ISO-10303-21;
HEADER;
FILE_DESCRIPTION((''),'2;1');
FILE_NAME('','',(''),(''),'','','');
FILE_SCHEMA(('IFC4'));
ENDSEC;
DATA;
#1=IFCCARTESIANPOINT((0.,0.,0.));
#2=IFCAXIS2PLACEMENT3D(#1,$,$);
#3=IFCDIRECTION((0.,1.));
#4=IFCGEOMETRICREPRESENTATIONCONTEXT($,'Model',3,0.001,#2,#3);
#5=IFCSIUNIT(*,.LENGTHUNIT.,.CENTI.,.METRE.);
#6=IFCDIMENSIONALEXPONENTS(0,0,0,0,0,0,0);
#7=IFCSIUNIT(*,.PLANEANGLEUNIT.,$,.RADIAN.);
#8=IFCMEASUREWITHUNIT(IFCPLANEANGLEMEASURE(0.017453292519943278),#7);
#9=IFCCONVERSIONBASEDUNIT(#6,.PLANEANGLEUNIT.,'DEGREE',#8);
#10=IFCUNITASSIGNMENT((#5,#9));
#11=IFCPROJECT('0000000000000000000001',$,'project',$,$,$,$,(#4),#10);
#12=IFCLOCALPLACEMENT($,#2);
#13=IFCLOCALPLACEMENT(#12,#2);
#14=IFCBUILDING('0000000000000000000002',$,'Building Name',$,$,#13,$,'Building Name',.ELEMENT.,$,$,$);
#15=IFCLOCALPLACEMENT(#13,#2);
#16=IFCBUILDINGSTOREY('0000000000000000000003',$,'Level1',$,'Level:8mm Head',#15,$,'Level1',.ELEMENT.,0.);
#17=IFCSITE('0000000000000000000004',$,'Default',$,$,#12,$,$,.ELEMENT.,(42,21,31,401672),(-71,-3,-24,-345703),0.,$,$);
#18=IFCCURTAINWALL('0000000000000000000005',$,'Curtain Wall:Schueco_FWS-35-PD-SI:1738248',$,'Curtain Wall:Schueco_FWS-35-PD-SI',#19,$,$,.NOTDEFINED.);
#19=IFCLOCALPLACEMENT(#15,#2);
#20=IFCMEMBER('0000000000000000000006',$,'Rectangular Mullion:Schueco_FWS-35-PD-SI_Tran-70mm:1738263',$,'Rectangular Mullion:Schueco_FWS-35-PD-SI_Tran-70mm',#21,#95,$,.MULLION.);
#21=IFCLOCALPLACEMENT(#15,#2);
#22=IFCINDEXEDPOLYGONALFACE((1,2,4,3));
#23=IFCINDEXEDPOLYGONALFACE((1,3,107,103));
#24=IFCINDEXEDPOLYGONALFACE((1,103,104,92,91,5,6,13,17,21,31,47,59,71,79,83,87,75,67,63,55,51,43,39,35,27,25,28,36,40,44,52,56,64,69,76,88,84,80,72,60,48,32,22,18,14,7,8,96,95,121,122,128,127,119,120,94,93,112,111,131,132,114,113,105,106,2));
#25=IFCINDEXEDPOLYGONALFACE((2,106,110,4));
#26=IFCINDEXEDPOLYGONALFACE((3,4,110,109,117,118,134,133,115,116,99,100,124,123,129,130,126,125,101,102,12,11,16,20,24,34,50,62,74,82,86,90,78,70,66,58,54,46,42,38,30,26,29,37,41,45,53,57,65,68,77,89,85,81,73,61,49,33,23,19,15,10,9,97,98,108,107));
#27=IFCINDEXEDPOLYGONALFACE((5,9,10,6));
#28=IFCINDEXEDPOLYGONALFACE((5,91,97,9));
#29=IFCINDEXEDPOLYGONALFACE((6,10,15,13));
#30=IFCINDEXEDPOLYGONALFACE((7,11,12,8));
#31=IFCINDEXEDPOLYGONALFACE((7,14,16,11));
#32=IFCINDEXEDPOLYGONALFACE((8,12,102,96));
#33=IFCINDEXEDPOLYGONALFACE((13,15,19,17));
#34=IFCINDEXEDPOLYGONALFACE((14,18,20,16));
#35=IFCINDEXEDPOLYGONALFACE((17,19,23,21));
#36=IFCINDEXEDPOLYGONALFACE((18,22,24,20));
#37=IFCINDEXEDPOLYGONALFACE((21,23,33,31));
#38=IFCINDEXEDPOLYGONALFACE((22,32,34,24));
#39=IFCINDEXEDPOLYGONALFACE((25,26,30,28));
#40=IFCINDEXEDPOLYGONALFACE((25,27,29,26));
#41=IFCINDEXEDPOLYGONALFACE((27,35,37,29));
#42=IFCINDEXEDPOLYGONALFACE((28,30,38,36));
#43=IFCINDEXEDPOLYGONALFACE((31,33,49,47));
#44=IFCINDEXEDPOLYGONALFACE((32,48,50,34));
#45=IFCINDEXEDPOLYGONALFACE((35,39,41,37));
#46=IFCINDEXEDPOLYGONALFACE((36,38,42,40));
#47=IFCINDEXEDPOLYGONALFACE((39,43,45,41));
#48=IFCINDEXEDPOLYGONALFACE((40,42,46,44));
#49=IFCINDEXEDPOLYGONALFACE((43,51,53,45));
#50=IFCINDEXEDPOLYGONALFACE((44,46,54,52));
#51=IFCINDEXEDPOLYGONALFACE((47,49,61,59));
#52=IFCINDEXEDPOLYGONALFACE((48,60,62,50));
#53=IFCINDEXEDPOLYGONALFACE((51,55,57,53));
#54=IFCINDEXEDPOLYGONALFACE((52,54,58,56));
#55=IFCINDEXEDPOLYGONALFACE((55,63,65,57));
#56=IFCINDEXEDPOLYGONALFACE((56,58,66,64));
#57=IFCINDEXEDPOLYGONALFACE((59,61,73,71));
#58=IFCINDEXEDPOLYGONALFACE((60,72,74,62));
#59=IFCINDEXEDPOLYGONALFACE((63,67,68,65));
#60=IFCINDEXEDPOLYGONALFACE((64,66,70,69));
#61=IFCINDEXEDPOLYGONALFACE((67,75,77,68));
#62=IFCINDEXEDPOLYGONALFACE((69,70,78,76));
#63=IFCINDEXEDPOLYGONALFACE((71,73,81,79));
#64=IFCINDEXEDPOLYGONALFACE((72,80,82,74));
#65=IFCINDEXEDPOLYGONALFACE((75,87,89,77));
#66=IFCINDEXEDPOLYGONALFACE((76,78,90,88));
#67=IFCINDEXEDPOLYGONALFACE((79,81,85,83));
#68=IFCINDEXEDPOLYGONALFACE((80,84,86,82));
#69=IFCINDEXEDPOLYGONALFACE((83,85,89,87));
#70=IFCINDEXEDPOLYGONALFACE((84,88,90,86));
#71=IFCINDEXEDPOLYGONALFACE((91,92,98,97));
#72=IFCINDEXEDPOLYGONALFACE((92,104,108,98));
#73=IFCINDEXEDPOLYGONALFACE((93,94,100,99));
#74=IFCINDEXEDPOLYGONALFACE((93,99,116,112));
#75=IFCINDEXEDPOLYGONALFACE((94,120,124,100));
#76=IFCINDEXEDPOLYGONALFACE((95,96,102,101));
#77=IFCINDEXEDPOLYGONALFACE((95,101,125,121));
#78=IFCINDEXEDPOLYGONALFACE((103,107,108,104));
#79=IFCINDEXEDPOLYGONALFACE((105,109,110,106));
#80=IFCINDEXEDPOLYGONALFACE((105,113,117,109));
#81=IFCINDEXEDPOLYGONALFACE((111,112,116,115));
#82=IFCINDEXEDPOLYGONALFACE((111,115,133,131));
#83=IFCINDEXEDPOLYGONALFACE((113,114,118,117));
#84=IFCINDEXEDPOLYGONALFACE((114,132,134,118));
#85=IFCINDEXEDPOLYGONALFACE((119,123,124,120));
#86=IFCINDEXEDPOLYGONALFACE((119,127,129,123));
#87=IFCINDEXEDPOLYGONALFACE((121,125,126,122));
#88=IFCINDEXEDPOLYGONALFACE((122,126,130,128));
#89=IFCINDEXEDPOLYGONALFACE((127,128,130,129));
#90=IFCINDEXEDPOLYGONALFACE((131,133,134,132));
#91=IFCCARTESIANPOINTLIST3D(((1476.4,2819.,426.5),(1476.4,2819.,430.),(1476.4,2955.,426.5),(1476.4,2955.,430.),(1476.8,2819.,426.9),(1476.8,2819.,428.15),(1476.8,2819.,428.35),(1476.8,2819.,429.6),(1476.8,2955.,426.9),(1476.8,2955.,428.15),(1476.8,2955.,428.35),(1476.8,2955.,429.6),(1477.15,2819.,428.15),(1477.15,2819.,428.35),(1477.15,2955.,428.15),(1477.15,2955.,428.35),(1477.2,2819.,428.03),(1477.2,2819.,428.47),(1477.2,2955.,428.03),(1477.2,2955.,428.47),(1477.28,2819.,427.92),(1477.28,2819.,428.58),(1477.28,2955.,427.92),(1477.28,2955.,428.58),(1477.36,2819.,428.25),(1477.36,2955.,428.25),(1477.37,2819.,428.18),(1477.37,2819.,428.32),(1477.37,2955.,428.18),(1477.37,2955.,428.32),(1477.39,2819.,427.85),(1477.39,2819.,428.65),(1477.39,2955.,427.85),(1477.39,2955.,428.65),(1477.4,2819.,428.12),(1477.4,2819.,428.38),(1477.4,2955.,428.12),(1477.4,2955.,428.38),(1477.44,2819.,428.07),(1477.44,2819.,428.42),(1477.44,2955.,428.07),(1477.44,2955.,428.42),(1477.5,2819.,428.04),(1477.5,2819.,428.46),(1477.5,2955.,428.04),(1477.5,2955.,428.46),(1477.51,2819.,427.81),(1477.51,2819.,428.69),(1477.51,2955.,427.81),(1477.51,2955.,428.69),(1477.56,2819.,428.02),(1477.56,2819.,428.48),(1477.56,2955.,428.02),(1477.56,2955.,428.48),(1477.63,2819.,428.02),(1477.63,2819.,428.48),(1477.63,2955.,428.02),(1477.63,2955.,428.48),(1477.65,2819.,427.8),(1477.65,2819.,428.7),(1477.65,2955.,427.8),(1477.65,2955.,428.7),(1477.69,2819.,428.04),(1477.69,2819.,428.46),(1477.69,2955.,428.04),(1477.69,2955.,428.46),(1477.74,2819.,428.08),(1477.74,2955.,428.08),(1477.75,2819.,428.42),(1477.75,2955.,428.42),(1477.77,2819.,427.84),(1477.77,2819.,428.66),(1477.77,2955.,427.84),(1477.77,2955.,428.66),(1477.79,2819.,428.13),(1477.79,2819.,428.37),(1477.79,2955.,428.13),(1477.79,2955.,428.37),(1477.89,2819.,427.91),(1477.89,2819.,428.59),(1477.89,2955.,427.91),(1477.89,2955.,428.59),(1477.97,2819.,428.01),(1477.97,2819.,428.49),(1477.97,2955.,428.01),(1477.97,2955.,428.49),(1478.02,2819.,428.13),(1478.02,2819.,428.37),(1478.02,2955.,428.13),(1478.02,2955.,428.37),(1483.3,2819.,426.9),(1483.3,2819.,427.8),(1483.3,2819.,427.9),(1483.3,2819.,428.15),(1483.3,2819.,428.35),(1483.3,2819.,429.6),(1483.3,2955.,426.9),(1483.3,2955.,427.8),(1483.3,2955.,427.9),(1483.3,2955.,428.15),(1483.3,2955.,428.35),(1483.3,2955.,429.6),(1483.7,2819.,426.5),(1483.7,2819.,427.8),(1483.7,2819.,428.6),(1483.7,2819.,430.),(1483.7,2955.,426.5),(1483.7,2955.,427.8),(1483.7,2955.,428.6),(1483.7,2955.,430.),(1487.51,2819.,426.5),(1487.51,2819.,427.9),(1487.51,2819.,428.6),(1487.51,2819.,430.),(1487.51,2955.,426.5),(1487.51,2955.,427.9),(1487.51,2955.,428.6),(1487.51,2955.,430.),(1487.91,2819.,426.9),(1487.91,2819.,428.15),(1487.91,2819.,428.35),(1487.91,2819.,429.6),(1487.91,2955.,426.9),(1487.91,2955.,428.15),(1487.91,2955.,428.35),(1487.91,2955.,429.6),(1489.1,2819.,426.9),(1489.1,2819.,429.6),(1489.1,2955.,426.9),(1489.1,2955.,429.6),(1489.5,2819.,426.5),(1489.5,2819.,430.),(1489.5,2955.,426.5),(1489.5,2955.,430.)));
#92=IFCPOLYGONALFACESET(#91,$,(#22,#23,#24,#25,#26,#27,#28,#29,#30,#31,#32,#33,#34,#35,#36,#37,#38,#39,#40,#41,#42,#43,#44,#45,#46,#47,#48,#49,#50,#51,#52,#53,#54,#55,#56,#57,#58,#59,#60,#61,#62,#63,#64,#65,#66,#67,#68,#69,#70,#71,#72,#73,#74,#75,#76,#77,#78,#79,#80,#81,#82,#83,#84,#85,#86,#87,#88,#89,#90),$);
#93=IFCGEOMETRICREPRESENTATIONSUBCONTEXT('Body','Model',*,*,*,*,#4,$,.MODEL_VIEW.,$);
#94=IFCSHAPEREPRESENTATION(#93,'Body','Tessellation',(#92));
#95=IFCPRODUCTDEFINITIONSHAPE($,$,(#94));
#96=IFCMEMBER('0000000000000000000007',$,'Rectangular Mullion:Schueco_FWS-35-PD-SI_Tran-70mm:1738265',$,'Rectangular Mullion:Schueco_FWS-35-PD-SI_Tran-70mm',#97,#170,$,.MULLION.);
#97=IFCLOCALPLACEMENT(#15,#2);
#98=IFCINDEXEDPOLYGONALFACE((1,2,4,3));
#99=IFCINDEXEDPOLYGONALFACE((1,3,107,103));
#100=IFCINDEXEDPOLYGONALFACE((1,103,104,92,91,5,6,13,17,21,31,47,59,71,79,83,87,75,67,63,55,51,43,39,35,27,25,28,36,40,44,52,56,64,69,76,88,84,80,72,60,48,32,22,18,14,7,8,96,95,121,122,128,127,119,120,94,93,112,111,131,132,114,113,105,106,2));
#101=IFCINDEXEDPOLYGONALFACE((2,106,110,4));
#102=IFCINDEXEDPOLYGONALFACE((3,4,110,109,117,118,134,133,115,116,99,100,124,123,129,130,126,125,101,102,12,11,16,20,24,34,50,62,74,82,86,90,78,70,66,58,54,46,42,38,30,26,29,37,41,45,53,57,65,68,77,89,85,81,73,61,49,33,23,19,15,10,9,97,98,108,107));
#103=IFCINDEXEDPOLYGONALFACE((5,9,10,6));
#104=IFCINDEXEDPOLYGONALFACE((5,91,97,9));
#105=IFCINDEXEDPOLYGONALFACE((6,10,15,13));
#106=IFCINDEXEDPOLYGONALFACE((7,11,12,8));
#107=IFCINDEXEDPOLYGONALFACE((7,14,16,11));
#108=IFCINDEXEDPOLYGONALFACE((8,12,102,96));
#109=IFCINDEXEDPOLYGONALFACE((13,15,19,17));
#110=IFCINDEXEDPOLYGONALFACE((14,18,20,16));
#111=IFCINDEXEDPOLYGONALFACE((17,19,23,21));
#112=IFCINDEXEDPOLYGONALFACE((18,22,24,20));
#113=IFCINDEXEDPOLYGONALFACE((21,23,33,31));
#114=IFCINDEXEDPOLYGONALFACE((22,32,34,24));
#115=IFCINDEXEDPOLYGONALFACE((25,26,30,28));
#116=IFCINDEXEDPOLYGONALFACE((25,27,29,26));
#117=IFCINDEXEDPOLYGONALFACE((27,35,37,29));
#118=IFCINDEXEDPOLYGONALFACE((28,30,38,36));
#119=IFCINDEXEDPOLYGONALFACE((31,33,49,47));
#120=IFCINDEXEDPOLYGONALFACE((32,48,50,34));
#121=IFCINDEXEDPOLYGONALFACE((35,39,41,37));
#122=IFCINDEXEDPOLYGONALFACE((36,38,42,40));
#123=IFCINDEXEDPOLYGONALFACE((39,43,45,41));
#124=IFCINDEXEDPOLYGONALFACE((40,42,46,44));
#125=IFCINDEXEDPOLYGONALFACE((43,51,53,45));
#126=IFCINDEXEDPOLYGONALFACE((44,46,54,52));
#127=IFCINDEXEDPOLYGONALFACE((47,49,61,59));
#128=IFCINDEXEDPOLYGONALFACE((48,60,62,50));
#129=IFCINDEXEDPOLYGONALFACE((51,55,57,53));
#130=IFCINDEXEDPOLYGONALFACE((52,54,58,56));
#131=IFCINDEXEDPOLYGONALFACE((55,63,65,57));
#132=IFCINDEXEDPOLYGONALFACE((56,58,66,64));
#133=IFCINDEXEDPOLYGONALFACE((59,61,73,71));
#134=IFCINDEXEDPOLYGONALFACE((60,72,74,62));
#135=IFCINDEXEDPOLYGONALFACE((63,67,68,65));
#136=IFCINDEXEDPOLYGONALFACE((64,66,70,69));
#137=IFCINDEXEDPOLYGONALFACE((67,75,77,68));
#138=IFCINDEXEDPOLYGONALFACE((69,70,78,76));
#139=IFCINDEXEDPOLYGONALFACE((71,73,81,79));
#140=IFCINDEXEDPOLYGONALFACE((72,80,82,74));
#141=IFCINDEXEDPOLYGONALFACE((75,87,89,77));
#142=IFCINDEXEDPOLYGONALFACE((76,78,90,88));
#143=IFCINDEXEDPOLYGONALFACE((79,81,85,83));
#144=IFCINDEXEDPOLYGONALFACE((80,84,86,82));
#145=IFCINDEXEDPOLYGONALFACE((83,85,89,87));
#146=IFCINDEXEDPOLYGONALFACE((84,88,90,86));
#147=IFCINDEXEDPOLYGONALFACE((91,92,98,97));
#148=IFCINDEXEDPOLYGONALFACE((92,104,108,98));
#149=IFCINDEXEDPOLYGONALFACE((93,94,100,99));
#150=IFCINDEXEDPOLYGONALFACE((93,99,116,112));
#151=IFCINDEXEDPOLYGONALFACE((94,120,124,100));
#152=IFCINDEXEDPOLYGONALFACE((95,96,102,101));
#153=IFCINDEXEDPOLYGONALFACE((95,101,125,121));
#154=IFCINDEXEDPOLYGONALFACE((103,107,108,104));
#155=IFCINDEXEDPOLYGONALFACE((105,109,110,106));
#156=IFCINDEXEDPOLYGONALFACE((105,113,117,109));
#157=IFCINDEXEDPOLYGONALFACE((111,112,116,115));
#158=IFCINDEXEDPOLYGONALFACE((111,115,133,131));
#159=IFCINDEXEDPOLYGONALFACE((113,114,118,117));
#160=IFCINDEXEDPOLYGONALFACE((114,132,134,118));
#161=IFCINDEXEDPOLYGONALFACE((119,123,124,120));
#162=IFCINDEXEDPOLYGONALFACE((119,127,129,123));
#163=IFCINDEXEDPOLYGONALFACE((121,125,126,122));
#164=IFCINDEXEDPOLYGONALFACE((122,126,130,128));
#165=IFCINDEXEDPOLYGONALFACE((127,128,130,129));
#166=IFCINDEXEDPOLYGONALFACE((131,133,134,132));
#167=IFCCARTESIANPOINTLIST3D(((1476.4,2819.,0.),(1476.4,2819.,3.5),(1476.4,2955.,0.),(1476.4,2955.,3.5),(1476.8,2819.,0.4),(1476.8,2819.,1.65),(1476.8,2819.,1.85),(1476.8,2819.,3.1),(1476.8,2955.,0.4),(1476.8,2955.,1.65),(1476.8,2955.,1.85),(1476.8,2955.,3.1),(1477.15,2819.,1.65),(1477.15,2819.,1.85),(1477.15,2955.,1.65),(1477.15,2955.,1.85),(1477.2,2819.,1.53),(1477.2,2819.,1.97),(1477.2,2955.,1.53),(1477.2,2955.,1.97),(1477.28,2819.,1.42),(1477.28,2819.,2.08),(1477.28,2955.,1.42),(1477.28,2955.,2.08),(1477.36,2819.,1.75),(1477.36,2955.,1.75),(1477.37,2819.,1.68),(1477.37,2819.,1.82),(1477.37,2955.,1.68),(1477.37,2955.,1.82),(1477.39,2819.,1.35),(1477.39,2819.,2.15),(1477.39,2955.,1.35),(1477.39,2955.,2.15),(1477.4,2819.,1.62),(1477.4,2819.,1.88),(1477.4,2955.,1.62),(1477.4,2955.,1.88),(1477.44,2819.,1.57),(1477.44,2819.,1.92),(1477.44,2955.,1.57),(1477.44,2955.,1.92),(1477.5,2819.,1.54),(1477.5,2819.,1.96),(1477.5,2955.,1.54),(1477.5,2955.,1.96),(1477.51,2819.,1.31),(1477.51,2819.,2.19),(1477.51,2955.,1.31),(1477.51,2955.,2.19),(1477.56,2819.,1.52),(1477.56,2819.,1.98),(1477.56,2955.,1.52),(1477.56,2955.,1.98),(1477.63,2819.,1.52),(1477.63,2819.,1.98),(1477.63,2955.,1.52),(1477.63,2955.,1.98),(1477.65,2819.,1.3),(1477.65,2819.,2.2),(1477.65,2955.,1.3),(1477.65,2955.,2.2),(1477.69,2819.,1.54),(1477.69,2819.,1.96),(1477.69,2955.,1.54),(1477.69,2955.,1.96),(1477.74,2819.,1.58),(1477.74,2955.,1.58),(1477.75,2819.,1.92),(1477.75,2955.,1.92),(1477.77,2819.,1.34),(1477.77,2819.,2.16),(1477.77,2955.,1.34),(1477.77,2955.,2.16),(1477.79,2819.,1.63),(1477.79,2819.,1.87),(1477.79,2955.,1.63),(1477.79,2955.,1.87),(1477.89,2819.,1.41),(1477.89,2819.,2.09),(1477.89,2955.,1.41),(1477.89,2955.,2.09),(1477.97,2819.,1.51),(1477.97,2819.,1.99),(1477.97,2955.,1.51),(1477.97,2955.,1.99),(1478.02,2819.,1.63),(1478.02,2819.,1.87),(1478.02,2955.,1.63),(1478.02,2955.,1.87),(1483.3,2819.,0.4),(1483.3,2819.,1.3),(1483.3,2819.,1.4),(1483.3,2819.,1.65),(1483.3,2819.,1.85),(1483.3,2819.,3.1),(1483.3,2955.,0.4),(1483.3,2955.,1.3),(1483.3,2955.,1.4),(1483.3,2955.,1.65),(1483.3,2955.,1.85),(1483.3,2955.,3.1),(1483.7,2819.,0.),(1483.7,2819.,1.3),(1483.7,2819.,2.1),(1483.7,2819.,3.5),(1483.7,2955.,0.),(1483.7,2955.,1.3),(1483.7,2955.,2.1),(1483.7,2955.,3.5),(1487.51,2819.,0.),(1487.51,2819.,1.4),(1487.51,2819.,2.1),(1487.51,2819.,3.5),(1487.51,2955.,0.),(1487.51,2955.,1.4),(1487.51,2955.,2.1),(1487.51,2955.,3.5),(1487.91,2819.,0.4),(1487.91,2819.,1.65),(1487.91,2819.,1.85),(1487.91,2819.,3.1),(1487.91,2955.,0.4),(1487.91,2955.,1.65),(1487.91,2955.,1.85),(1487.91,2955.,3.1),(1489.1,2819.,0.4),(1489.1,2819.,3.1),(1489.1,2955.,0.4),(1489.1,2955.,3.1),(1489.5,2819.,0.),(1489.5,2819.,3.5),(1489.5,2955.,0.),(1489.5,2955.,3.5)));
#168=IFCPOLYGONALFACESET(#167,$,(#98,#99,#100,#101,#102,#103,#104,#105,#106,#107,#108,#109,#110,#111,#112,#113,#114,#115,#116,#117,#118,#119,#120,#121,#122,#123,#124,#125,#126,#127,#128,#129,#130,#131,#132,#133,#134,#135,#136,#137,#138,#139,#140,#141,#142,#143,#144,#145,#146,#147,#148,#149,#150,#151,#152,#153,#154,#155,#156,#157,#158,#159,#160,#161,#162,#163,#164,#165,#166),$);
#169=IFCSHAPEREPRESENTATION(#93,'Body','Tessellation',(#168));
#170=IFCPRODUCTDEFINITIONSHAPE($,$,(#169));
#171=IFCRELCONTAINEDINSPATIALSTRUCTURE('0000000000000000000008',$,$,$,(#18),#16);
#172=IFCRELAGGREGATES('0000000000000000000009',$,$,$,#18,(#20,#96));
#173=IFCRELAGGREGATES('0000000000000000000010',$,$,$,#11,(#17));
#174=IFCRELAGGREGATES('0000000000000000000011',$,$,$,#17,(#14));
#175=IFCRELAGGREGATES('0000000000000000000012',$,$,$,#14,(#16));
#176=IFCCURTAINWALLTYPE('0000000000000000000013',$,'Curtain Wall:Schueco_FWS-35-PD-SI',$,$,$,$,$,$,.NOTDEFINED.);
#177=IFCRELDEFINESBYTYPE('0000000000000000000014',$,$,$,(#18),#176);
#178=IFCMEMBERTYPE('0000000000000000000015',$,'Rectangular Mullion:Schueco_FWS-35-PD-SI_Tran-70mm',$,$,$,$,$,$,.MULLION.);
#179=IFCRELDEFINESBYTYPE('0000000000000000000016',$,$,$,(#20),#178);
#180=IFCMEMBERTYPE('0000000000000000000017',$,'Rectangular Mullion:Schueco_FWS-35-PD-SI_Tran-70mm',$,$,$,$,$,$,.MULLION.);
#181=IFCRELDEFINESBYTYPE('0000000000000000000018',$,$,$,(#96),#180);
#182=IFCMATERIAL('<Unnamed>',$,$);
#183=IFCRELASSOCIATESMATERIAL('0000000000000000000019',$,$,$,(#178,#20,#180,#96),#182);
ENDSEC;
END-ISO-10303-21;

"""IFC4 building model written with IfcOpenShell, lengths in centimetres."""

from ifc_helpers import new_model, entity, si_unit, converted_unit, direction, frame, origin, place, context, subcontext, project, spatial, line, arc, indexed_curve, outline, extrude, source, transform, mapped, material, type_object, type_shapes, element, aggregate, save


model = new_model("IFC4")

# Units and contexts
model_context = context("Model", 3, precision=0.001, world=origin(), true_north=direction((0.0, 1.0)))
body_context = subcontext(model_context, "Body", "Model", "MODEL_VIEW")
ifc_project = project(units=[si_unit("LENGTHUNIT", "METRE", prefix="CENTI"), converted_unit("PLANEANGLEUNIT", "DEGREE", entity("IfcPlaneAngleMeasure", 0.017453292519943278), si_unit("PLANEANGLEUNIT", "RADIAN"), dimensions=[0, 0, 0, 0, 0, 0, 0])], contexts=[model_context])

# Site, building, storey
site_placement = place(None, origin())
site = spatial("IfcSite", under=ifc_project, at=site_placement, Name="Default", CompositionType="ELEMENT", RefLatitude=(42, 21, 31, 401672), RefLongitude=(-71, -3, -24, -345703), RefElevation=0.0)
building_placement = place(site_placement, origin())
building = spatial("IfcBuilding", under=site, at=building_placement, Name="Building Name", LongName="Building Name", CompositionType="ELEMENT")
storey_placement = place(building_placement, origin())
storey = spatial("IfcBuildingStorey", under=building, at=storey_placement, Name="Level1", ObjectType="Level:8mm Head", LongName="Level1", CompositionType="ELEMENT", Elevation=0.0)

# Curtain wall, members
curtain_wall_type = type_object("IfcCurtainWallType", Name="Curtain Wall:Schueco_FWS-35-PD-SI", PredefinedType="NOTDEFINED")
curtain_wall_placement = place(storey_placement, origin())
curtain_wall = element("IfcCurtainWall", 1, at=curtain_wall_placement, inside=storey, type_object=curtain_wall_type, Name="Curtain Wall:Schueco_FWS-35-PD-SI:1738248", ObjectType="Curtain Wall:Schueco_FWS-35-PD-SI", PredefinedType="NOTDEFINED")
ifc_material_1 = material(Name="<Unnamed>")
member_type_1 = type_object("IfcMemberType", Name="Rectangular Mullion:Schueco_FWS-35-PD-SI_Tran-70mm", PredefinedType="MULLION", material=ifc_material_1)
shared_shape_1 = source(origin(), body_context, "Body", "SweptSolid", [
    extrude(outline(indexed_curve([(-1.78, -6.52), (1.72, -6.52), (1.72, 0.78), (0.42, 0.78), (0.42, 0.38), (1.32, 0.38), (1.32, -6.12), (0.07, -6.12), (0.07, -5.77), (0.42, -5.34), (0.09, -4.9), (0.09, -5.14), (-0.03, -5.56), (-0.15, -5.14), (-0.15, -4.9), (-0.48, -5.34), (-0.13, -5.77), (-0.13, -6.12), (-1.38, -6.12), (-1.38, 0.38), (-0.13, 0.38), (-0.13, 4.99), (-1.38, 4.99), (-1.38, 6.18), (1.32, 6.18), (1.32, 4.99), (0.07, 4.99), (0.07, 0.38), (0.32, 0.38), (0.32, 4.59), (1.72, 4.59), (1.72, 6.58), (-1.78, 6.58), (-1.78, 4.59), (-0.38, 4.59), (-0.38, 0.78), (-1.78, 0.78)], segments=[line(1, 2, 3, 4, 5, 6, 7, 8, 9), arc(9, 10, 11), line(11, 12), arc(12, 13, 14), line(14, 15), arc(15, 16, 17), line(17, 18, 19, 20, 21, 22, 23, 24, 25, 26, 27, 28, 29, 30, 31, 32, 33, 34, 35, 36, 37, 1)], self_intersect=False)), frame((-1.78, 4.58, -136.0), z_axis=(0.0, 0.0, 1.0), x_axis=(-1.0, 0.0, 0.0)), (0.0, 0.0, 1.0), 136.0),
])
type_shapes(member_type_1, [shared_shape_1])
member_1_placement = place(curtain_wall_placement, frame((1487.5, 2819.0, 430.0), z_axis=(0.0, -1.0, 0.0), x_axis=(0.0, 0.0, 1.0)))
member_1 = element("IfcMember", 2, at=member_1_placement, type_object=member_type_1, material=ifc_material_1, Name="Rectangular Mullion:Schueco_FWS-35-PD-SI_Tran-70mm:1738263", ObjectType="Rectangular Mullion:Schueco_FWS-35-PD-SI_Tran-70mm", PredefinedType="MULLION", context=body_context, shape_type="MappedRepresentation", body=[
    mapped(shared_shape_1, transform((0.0, 0.0, 0.0), scale=1.0)),
])
member_type_2 = type_object("IfcMemberType", Name="Rectangular Mullion:Schueco_FWS-35-PD-SI_Tran-70mm", PredefinedType="MULLION", material=ifc_material_1)
shared_shape_2 = source(origin(), body_context, "Body", "SweptSolid", [
    extrude(outline(indexed_curve([(-6.52, -1.78), (0.78, -1.78), (0.78, -0.38), (4.59, -0.38), (4.59, -1.78), (6.58, -1.78), (6.58, 1.72), (4.59, 1.72), (4.59, 0.32), (0.38, 0.32), (0.38, 0.07), (4.99, 0.07), (4.99, 1.32), (6.18, 1.32), (6.18, -1.38), (4.99, -1.38), (4.99, -0.13), (0.38, -0.13), (0.38, -1.38), (-6.12, -1.38), (-6.12, -0.13), (-5.77, -0.13), (-5.34, -0.48), (-4.9, -0.15), (-5.14, -0.15), (-5.56, -0.03), (-5.14, 0.09), (-4.9, 0.09), (-5.34, 0.42), (-5.77, 0.07), (-6.12, 0.07), (-6.12, 1.32), (0.38, 1.32), (0.38, 0.42), (0.78, 0.42), (0.78, 1.72), (-6.52, 1.72)], segments=[line(1, 2, 3, 4, 5, 6, 7, 8, 9, 10, 11, 12, 13, 14, 15, 16, 17, 18, 19, 20, 21, 22), arc(22, 23, 24), line(24, 25), arc(25, 26, 27), line(27, 28), arc(28, 29, 30), line(30, 31, 32, 33, 34, 35, 36, 37, 1)], self_intersect=False)), frame((-1.72, 4.58, -136.0), z_axis=(0.0, 0.0, 1.0), x_axis=(0.0, -1.0, 0.0)), (0.0, 0.0, 1.0), 136.0),
])
type_shapes(member_type_2, [shared_shape_2])
member_2_placement = place(curtain_wall_placement, frame((1487.5, 2955.0, 0.0), z_axis=(0.0, 1.0, 0.0), x_axis=(0.0, 0.0, -1.0)))
member_2 = element("IfcMember", 3, at=member_2_placement, type_object=member_type_2, material=ifc_material_1, Name="Rectangular Mullion:Schueco_FWS-35-PD-SI_Tran-70mm:1738265", ObjectType="Rectangular Mullion:Schueco_FWS-35-PD-SI_Tran-70mm", PredefinedType="MULLION", context=body_context, shape_type="MappedRepresentation", body=[
    mapped(shared_shape_2, transform((0.0, 0.0, 0.0), scale=1.0)),
])
aggregate(curtain_wall, [member_1, member_2])

save(model, "model.ifc")
